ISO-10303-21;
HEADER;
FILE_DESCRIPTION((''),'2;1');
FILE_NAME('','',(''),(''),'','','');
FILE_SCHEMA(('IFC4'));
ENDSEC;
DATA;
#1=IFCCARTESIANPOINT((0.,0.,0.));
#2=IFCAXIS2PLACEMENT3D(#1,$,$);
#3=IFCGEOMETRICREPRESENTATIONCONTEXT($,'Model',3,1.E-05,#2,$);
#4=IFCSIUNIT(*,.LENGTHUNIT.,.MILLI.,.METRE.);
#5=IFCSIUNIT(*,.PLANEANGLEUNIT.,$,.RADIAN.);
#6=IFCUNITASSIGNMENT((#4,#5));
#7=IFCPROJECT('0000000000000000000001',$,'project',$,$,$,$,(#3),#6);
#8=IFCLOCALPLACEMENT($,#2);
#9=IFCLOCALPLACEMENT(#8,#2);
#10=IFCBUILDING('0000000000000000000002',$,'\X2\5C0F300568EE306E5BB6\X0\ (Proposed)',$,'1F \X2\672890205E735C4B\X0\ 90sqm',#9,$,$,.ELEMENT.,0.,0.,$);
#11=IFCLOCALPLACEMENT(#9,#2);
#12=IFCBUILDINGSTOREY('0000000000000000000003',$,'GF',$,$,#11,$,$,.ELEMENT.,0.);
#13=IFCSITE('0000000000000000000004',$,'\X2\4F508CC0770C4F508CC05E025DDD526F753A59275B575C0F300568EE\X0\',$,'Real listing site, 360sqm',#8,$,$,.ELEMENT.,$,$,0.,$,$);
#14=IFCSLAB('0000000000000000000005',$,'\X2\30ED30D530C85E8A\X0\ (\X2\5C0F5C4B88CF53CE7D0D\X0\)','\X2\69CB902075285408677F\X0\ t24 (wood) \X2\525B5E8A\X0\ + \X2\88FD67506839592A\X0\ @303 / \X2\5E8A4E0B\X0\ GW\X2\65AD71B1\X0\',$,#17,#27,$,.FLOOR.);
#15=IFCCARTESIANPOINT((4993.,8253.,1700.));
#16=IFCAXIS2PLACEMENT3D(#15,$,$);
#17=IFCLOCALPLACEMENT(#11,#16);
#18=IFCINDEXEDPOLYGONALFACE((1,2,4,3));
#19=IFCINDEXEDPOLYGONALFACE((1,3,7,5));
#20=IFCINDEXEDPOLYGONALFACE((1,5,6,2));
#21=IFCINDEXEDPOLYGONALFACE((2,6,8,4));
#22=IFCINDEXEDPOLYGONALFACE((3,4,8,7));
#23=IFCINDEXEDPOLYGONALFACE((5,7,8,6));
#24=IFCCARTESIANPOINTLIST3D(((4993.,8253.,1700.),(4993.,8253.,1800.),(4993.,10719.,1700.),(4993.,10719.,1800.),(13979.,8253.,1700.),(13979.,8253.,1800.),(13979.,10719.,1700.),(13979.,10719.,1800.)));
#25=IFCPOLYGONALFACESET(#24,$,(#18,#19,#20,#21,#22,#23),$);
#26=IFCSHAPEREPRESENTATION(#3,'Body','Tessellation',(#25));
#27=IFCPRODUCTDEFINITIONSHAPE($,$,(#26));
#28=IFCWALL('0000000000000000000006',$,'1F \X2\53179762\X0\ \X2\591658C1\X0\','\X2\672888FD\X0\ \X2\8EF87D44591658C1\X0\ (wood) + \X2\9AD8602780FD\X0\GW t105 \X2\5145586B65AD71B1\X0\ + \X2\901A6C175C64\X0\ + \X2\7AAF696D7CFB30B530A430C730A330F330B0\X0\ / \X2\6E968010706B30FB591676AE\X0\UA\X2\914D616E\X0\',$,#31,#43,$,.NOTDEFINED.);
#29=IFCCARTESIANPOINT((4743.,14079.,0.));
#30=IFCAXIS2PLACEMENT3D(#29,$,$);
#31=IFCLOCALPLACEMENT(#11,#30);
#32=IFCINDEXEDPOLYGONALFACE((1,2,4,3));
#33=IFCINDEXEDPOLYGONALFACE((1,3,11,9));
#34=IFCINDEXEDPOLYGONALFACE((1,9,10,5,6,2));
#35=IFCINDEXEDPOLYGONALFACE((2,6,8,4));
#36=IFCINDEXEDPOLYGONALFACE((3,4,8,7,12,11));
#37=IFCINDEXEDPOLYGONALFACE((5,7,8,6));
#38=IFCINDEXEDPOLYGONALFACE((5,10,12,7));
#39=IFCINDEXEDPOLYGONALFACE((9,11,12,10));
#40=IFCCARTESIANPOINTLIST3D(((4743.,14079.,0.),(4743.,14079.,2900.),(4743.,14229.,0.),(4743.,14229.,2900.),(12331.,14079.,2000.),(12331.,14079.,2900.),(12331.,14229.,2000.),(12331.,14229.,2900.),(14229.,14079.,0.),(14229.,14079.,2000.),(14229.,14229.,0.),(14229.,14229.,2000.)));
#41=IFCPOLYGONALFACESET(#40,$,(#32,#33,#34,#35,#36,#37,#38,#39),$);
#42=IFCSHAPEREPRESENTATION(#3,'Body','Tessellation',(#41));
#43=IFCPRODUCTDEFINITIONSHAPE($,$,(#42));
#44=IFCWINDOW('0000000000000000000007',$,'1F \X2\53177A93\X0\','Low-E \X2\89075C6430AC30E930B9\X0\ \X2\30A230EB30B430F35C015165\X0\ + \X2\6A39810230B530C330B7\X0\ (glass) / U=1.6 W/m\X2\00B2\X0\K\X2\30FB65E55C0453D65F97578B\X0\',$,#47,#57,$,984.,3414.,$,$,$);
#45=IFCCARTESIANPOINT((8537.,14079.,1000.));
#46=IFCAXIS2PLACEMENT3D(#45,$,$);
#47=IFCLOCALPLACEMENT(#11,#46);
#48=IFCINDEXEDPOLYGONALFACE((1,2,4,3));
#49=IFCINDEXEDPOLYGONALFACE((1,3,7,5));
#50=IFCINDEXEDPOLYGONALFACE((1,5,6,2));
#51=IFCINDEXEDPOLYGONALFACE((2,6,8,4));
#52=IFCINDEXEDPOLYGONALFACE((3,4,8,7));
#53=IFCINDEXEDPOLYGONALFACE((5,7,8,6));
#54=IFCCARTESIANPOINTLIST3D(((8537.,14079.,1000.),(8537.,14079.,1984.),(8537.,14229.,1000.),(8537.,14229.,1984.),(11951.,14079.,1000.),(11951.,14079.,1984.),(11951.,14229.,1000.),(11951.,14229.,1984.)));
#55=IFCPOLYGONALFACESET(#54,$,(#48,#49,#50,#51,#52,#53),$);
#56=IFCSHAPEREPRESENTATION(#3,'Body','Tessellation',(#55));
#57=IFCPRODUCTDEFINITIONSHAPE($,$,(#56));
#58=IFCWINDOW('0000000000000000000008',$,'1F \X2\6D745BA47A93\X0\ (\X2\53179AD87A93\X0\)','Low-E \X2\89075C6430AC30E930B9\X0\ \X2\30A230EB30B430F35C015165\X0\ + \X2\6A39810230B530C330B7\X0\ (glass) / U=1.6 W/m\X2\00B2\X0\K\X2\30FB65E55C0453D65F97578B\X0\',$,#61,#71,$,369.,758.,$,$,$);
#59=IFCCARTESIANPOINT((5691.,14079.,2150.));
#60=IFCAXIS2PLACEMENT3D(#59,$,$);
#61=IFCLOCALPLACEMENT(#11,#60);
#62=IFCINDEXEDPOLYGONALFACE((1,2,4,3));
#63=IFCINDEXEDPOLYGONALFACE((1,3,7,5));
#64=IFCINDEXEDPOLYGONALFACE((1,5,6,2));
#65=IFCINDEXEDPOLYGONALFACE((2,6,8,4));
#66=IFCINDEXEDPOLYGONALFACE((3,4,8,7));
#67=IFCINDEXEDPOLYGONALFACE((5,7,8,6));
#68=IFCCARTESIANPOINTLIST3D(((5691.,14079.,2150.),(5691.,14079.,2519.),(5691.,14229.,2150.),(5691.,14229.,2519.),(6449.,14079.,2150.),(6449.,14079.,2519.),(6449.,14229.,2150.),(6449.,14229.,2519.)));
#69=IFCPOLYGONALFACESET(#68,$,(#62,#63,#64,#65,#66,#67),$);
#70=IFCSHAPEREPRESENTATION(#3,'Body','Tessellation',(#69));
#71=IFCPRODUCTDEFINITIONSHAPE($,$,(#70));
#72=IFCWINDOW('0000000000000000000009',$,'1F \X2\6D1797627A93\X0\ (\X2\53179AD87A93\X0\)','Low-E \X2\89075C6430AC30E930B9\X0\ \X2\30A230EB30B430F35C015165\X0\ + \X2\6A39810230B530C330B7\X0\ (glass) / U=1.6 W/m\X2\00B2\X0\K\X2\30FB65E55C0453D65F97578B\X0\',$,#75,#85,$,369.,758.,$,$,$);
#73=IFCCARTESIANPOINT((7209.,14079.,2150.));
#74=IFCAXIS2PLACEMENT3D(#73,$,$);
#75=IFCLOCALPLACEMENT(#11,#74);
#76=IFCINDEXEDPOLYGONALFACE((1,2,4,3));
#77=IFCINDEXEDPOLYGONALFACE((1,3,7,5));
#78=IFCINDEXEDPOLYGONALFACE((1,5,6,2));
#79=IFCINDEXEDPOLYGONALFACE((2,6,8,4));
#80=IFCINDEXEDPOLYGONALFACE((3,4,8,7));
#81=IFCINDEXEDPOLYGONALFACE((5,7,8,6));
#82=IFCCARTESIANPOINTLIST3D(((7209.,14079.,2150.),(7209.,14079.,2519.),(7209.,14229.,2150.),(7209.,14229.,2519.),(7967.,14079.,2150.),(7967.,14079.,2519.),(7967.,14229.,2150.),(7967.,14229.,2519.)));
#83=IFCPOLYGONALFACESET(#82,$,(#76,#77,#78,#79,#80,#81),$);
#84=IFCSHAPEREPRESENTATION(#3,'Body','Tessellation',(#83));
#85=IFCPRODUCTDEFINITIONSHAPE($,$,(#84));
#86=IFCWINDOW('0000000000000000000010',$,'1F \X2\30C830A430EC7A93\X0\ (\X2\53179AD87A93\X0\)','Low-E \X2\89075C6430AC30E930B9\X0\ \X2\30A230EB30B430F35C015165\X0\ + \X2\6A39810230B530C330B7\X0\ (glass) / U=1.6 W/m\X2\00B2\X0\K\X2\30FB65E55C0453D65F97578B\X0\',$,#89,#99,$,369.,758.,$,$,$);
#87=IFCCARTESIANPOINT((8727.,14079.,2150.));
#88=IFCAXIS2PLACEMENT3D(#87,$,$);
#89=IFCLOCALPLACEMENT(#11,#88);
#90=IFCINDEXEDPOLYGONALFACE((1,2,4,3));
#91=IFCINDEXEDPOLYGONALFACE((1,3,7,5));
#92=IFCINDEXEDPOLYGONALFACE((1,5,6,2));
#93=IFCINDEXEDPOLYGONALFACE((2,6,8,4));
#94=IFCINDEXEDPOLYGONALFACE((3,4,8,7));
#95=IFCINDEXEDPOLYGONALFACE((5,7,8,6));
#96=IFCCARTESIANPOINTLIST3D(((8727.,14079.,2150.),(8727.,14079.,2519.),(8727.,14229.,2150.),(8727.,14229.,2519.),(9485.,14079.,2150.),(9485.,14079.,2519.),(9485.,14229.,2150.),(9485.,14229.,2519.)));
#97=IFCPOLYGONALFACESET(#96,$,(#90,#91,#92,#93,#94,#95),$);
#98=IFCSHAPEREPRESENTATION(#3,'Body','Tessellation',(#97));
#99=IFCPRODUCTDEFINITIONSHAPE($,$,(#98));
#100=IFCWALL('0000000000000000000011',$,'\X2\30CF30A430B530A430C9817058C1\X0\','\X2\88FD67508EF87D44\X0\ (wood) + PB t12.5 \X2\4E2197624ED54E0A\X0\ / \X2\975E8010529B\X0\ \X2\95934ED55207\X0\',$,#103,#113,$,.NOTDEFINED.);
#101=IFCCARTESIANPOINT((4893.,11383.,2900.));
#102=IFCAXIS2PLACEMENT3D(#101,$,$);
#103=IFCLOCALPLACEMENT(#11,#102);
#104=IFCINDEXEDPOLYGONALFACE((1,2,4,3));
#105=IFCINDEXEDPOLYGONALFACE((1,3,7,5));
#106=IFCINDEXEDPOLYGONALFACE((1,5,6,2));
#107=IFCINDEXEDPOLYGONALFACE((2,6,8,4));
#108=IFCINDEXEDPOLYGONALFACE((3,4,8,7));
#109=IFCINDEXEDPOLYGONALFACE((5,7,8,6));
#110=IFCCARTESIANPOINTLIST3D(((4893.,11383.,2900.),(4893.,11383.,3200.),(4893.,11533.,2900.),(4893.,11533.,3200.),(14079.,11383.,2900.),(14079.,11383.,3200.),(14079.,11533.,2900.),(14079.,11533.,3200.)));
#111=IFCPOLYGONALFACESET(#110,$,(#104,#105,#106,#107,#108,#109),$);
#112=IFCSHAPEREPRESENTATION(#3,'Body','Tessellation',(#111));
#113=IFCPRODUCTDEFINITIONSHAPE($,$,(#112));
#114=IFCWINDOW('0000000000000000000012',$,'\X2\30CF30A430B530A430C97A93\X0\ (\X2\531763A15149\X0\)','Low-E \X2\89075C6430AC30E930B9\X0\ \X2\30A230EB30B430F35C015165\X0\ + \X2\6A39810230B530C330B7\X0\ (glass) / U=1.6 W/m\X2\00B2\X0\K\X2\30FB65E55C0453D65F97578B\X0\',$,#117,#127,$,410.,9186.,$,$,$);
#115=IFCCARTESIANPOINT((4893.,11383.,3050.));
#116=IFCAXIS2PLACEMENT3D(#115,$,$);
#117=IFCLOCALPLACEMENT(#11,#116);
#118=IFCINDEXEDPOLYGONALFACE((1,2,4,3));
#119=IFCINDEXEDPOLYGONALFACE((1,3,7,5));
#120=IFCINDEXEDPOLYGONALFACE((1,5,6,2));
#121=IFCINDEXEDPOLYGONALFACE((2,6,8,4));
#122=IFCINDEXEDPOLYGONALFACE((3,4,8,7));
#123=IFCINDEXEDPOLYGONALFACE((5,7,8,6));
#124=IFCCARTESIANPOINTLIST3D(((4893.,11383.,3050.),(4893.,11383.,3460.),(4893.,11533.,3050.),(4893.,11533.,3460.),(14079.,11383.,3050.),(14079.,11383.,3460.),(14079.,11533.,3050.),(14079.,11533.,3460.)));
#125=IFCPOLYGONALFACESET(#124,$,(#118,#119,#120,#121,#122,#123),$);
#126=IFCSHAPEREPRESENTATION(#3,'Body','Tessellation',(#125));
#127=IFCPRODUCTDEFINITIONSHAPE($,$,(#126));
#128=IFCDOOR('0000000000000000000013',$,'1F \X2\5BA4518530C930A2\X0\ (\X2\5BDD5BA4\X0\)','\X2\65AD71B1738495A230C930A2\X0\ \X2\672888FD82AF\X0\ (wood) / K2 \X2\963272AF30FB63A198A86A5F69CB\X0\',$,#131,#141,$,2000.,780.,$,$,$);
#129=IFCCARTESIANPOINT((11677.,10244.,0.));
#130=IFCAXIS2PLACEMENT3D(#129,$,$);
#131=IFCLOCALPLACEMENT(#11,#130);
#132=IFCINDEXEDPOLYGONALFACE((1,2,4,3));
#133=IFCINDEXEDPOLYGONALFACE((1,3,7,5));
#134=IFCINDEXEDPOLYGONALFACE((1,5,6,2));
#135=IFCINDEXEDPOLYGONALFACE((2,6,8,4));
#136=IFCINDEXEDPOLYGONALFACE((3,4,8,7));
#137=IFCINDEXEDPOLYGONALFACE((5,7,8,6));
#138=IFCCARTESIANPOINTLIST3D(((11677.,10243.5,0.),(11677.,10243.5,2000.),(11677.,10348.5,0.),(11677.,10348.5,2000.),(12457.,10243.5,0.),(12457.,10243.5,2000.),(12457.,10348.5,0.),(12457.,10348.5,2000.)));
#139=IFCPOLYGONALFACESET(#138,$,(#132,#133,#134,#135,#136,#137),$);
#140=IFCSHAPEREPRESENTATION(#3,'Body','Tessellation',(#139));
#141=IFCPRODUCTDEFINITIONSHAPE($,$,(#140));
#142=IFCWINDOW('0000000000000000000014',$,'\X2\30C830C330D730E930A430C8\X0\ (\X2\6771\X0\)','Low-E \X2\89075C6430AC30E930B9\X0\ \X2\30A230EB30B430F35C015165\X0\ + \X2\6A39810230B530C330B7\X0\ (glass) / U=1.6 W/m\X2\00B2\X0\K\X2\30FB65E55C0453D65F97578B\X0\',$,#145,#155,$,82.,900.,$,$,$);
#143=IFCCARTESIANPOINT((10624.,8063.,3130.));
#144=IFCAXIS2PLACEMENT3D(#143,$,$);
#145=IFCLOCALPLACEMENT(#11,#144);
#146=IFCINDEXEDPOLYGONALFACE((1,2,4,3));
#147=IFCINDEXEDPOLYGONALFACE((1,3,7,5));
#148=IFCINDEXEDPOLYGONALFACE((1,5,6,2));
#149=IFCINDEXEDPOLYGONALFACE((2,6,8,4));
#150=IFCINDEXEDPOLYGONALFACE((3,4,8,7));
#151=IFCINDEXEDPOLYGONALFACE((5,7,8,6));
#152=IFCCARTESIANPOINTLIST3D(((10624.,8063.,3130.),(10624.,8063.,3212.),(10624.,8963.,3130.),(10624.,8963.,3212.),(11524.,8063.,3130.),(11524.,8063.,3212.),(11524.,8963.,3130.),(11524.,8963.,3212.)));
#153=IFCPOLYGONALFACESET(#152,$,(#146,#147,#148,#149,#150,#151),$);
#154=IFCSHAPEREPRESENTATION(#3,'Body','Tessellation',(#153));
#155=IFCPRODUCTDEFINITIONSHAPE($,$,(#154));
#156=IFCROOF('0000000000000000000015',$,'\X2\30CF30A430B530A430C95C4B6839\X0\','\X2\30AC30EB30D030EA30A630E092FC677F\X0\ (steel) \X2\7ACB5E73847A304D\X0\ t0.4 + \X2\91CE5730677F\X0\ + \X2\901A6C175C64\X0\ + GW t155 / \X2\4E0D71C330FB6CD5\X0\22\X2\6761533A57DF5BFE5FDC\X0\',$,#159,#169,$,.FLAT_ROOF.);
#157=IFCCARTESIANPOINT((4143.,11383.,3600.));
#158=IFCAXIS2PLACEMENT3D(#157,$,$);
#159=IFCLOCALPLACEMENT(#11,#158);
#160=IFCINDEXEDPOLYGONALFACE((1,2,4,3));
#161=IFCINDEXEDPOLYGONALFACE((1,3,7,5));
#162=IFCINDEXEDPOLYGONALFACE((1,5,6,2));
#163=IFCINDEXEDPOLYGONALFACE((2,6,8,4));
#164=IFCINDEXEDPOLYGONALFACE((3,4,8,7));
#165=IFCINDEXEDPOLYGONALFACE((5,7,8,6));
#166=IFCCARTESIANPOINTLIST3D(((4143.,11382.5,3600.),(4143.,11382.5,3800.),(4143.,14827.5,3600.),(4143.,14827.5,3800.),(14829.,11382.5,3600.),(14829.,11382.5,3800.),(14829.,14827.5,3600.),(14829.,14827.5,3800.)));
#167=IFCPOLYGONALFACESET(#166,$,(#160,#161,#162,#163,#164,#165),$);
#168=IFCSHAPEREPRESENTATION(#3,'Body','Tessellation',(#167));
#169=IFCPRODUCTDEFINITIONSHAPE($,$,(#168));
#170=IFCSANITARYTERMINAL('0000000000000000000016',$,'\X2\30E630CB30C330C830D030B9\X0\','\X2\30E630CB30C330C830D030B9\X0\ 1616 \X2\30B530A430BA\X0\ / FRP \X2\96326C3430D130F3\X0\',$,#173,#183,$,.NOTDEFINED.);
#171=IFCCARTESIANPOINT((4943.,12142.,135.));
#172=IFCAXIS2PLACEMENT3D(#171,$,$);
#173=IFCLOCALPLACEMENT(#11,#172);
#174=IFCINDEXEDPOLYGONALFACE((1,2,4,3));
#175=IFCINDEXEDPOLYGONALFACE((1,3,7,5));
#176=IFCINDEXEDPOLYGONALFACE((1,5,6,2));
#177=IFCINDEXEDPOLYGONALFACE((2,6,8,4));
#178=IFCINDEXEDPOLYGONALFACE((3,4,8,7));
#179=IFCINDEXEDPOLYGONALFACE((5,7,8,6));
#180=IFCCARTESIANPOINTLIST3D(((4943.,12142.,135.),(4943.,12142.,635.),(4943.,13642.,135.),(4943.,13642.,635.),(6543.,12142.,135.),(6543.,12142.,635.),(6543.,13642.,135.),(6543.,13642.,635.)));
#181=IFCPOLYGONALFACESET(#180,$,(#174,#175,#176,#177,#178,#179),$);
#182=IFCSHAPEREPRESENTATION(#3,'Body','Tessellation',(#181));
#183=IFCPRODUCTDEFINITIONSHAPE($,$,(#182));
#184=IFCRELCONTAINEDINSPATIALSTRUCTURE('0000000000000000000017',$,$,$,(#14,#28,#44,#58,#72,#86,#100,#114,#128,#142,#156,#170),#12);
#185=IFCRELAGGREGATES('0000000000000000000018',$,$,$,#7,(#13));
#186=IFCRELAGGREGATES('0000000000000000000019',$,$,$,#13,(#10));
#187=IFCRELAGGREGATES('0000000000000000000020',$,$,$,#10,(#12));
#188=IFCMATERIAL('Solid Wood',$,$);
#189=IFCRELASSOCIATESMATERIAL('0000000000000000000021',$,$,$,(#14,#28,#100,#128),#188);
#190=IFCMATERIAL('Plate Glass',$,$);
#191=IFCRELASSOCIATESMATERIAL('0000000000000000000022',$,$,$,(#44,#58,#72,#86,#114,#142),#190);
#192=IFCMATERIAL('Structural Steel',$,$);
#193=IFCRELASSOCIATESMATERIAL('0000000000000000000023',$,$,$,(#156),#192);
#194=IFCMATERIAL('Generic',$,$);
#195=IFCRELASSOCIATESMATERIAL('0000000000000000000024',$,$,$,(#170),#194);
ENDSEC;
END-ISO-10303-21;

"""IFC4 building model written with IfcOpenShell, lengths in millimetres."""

from ifc_helpers import new_model, si_unit, frame, frame_2d, origin, place, context, project, spatial, rectangle, extrude, material, element, fill, save


model = new_model("IFC4")

# Units and contexts
model_context = context("Model", 3, precision=1e-05, world=origin())
ifc_project = project(units=[si_unit("LENGTHUNIT", "METRE", prefix="MILLI"), si_unit("PLANEANGLEUNIT", "RADIAN")], contexts=[model_context])

# Site, building, storey
site_placement = place(None, origin())
site = spatial("IfcSite", under=ifc_project, at=site_placement, Name="佐賀県佐賀市川副町大字小々森", ObjectType="Real listing site, 360sqm", CompositionType="ELEMENT", RefElevation=0.0)
building_placement = place(site_placement, origin())
building = spatial("IfcBuilding", under=site, at=building_placement, Name="小々森の家 (Proposed)", ObjectType="1F 木造平屋 90sqm", CompositionType="ELEMENT", ElevationOfRefHeight=0.0, ElevationOfTerrain=0.0)
storey_placement = place(building_placement, origin())
storey = spatial("IfcBuildingStorey", under=building, at=storey_placement, Name="GF", CompositionType="ELEMENT", Elevation=0.0)

# Slab
ifc_material_1 = material(Name="Solid Wood")
slab_placement = place(storey_placement, frame((4993.0, 8253.0, 1700.0)))
element("IfcSlab", 1, at=slab_placement, inside=storey, material=ifc_material_1, Name="ロフト床 (小屋裏収納)", Description="構造用合板 t24 (wood) 剛床 + 製材根太 @303 / 床下 GW断熱", PredefinedType="FLOOR", context=model_context, shape_type="SweptSolid", body=[
    extrude(rectangle(XDim=8986.0, YDim=2466.0, at=frame_2d((4493.0, 1233.0))), frame((4993.0, 8253.0, 1700.0)), (0.0, 0.0, 1.0), 100.0),
])

# Wall, openings, windows
wall_1_placement = place(storey_placement, frame((4743.0, 14079.0, 0.0)))
wall_1 = element("IfcWall", 2, at=wall_1_placement, inside=storey, material=ifc_material_1, Name="1F 北面 外壁", Description="木製 軸組外壁 (wood) + 高性能GW t105 充填断熱 + 通気層 + 窯業系サイディング / 準耐火・外皮UA配慮", PredefinedType="NOTDEFINED", context=model_context, shape_type="SweptSolid", body=[
    extrude(rectangle(XDim=9486.0, YDim=150.0, at=frame_2d((4743.0, 75.0))), frame((4743.0, 14079.0, 0.0)), (0.0, 0.0, 1.0), 2900.0),
])
opening_1_placement = place(storey_placement, frame((8537.0, 14079.0, 1000.0)))
opening_1 = element("IfcOpeningElement", 3, at=opening_1_placement, cuts=wall_1, PredefinedType="NOTDEFINED", context=model_context, shape_type="SweptSolid", body=[
    extrude(rectangle(XDim=3414.0, YDim=150.0, at=frame_2d((1707.0, 75.0))), frame((8537.0, 14079.0, 1000.0)), (0.0, 0.0, 1.0), 984.0),
])
opening_2_placement = place(storey_placement, frame((5691.0, 14079.0, 2150.0)))
opening_2 = element("IfcOpeningElement", 4, at=opening_2_placement, cuts=wall_1, PredefinedType="NOTDEFINED", context=model_context, shape_type="SweptSolid", body=[
    extrude(rectangle(XDim=758.0, YDim=150.0, at=frame_2d((379.0, 75.0))), frame((5691.0, 14079.0, 2150.0)), (0.0, 0.0, 1.0), 369.0),
])
opening_3_placement = place(storey_placement, frame((7209.0, 14079.0, 2150.0)))
opening_3 = element("IfcOpeningElement", 5, at=opening_3_placement, cuts=wall_1, PredefinedType="NOTDEFINED", context=model_context, shape_type="SweptSolid", body=[
    extrude(rectangle(XDim=758.0, YDim=150.0, at=frame_2d((379.0, 75.0))), frame((7209.0, 14079.0, 2150.0)), (0.0, 0.0, 1.0), 369.0),
])
opening_4_placement = place(storey_placement, frame((8727.0, 14079.0, 2150.0)))
opening_4 = element("IfcOpeningElement", 6, at=opening_4_placement, cuts=wall_1, PredefinedType="NOTDEFINED", context=model_context, shape_type="SweptSolid", body=[
    extrude(rectangle(XDim=758.0, YDim=150.0, at=frame_2d((379.0, 75.0))), frame((8727.0, 14079.0, 2150.0)), (0.0, 0.0, 1.0), 369.0),
])
ifc_material_2 = material(Name="Plate Glass")
window_1_placement = place(storey_placement, frame((8537.0, 14079.0, 1000.0)))
window_1 = element("IfcWindow", 7, at=window_1_placement, inside=storey, material=ifc_material_2, Name="1F 北窓", Description="Low-E 複層ガラス アルゴン封入 + 樹脂サッシ (glass) / U=1.6 W/m²K・日射取得型", OverallHeight=984.0, OverallWidth=3414.0, context=model_context, shape_type="SweptSolid", body=[
    extrude(rectangle(XDim=3414.0, YDim=150.0, at=frame_2d((1707.0, 75.0))), frame((8537.0, 14079.0, 1000.0)), (0.0, 0.0, 1.0), 984.0),
])
fill(opening_1, window_1)
window_2_placement = place(storey_placement, frame((5691.0, 14079.0, 2150.0)))
window_2 = element("IfcWindow", 8, at=window_2_placement, inside=storey, material=ifc_material_2, Name="1F 浴室窓 (北高窓)", Description="Low-E 複層ガラス アルゴン封入 + 樹脂サッシ (glass) / U=1.6 W/m²K・日射取得型", OverallHeight=369.0, OverallWidth=758.0, context=model_context, shape_type="SweptSolid", body=[
    extrude(rectangle(XDim=758.0, YDim=150.0, at=frame_2d((379.0, 75.0))), frame((5691.0, 14079.0, 2150.0)), (0.0, 0.0, 1.0), 369.0),
])
fill(opening_2, window_2)
window_3_placement = place(storey_placement, frame((7209.0, 14079.0, 2150.0)))
window_3 = element("IfcWindow", 9, at=window_3_placement, inside=storey, material=ifc_material_2, Name="1F 洗面窓 (北高窓)", Description="Low-E 複層ガラス アルゴン封入 + 樹脂サッシ (glass) / U=1.6 W/m²K・日射取得型", OverallHeight=369.0, OverallWidth=758.0, context=model_context, shape_type="SweptSolid", body=[
    extrude(rectangle(XDim=758.0, YDim=150.0, at=frame_2d((379.0, 75.0))), frame((7209.0, 14079.0, 2150.0)), (0.0, 0.0, 1.0), 369.0),
])
fill(opening_3, window_3)
window_4_placement = place(storey_placement, frame((8727.0, 14079.0, 2150.0)))
window_4 = element("IfcWindow", 10, at=window_4_placement, inside=storey, material=ifc_material_2, Name="1F トイレ窓 (北高窓)", Description="Low-E 複層ガラス アルゴン封入 + 樹脂サッシ (glass) / U=1.6 W/m²K・日射取得型", OverallHeight=369.0, OverallWidth=758.0, context=model_context, shape_type="SweptSolid", body=[
    extrude(rectangle(XDim=758.0, YDim=150.0, at=frame_2d((379.0, 75.0))), frame((8727.0, 14079.0, 2150.0)), (0.0, 0.0, 1.0), 369.0),
])
fill(opening_4, window_4)

# Wall, opening, window
wall_2_placement = place(storey_placement, frame((4893.0, 11383.0, 2900.0)))
wall_2 = element("IfcWall", 11, at=wall_2_placement, inside=storey, material=ifc_material_1, Name="ハイサイド腰壁", Description="製材軸組 (wood) + PB t12.5 両面仕上 / 非耐力 間仕切", PredefinedType="NOTDEFINED", context=model_context, shape_type="SweptSolid", body=[
    extrude(rectangle(XDim=9186.0, YDim=150.0, at=frame_2d((4593.0, 75.0))), frame((4893.0, 11383.0, 2900.0)), (0.0, 0.0, 1.0), 700.0),
])
opening_5_placement = place(storey_placement, frame((4893.0, 11383.0, 3050.0)))
opening_5 = element("IfcOpeningElement", 12, at=opening_5_placement, cuts=wall_2, PredefinedType="NOTDEFINED", context=model_context, shape_type="SweptSolid", body=[
    extrude(rectangle(XDim=9186.0, YDim=150.0, at=frame_2d((4593.0, 75.0))), frame((4893.0, 11383.0, 3050.0)), (0.0, 0.0, 1.0), 410.0),
])
window_5_placement = place(storey_placement, frame((4893.0, 11383.0, 3050.0)))
window_5 = element("IfcWindow", 13, at=window_5_placement, inside=storey, material=ifc_material_2, Name="ハイサイド窓 (北採光)", Description="Low-E 複層ガラス アルゴン封入 + 樹脂サッシ (glass) / U=1.6 W/m²K・日射取得型", OverallHeight=410.0, OverallWidth=9186.0, context=model_context, shape_type="SweptSolid", body=[
    extrude(rectangle(XDim=9186.0, YDim=150.0, at=frame_2d((4593.0, 75.0))), frame((4893.0, 11383.0, 3050.0)), (0.0, 0.0, 1.0), 410.0),
])
fill(opening_5, window_5)

# Door
door_1_placement = place(storey_placement, frame((11677.0, 10244.0, 0.0)))
element("IfcDoor", 14, at=door_1_placement, inside=storey, material=ifc_material_1, Name="1F 室内ドア (寝室)", Description="断熱玄関ドア 木製芯 (wood) / K2 防犯・採風機構", OverallHeight=2000.0, OverallWidth=780.0, context=model_context, shape_type="SweptSolid", body=[
    extrude(rectangle(XDim=780.0, YDim=105.0, at=frame_2d((390.0, 52.0))), frame((11677.0, 10244.0, 0.0)), (0.0, 0.0, 1.0), 2000.0),
])

# Window
window_6_placement = place(storey_placement, frame((10624.0, 8063.0, 3130.0)))
element("IfcWindow", 15, at=window_6_placement, inside=storey, material=ifc_material_2, Name="トップライト (東)", Description="Low-E 複層ガラス アルゴン封入 + 樹脂サッシ (glass) / U=1.6 W/m²K・日射取得型", OverallHeight=82.0, OverallWidth=900.0, context=model_context, shape_type="SweptSolid", body=[
    extrude(rectangle(XDim=900.0, YDim=900.0, at=frame_2d((450.0, 450.0))), frame((10624.0, 8063.0, 3130.0)), (0.0, 0.0, 1.0), 82.0),
])

# Roof
ifc_material_3 = material(Name="Structural Steel")
roof_placement = place(storey_placement, frame((4143.0, 11383.0, 3600.0)))
element("IfcRoof", 16, at=roof_placement, inside=storey, material=ifc_material_3, Name="ハイサイド屋根", Description="ガルバリウム鋼板 (steel) 立平葺き t0.4 + 野地板 + 通気層 + GW t155 / 不燃・法22条区域対応", PredefinedType="FLAT_ROOF", context=model_context, shape_type="SweptSolid", body=[
    extrude(rectangle(XDim=10686.0, YDim=3445.0, at=frame_2d((5343.0, 1722.0))), frame((4143.0, 11383.0, 3600.0)), (0.0, 0.0, 1.0), 200.0),
])

# Sanitary terminal
ifc_material_4 = material(Name="Generic")
sanitary_terminal_1_placement = place(storey_placement, frame((4943.0, 12142.0, 135.0)))
element("IfcSanitaryTerminal", 17, at=sanitary_terminal_1_placement, inside=storey, material=ifc_material_4, Name="ユニットバス", Description="ユニットバス 1616 サイズ / FRP 防水パン", PredefinedType="NOTDEFINED", context=model_context, shape_type="SweptSolid", body=[
    extrude(rectangle(XDim=1600.0, YDim=1500.0, at=frame_2d((800.0, 750.0))), frame((4943.0, 12142.0, 135.0)), (0.0, 0.0, 1.0), 500.0),
])

save(model, "model.ifc")
